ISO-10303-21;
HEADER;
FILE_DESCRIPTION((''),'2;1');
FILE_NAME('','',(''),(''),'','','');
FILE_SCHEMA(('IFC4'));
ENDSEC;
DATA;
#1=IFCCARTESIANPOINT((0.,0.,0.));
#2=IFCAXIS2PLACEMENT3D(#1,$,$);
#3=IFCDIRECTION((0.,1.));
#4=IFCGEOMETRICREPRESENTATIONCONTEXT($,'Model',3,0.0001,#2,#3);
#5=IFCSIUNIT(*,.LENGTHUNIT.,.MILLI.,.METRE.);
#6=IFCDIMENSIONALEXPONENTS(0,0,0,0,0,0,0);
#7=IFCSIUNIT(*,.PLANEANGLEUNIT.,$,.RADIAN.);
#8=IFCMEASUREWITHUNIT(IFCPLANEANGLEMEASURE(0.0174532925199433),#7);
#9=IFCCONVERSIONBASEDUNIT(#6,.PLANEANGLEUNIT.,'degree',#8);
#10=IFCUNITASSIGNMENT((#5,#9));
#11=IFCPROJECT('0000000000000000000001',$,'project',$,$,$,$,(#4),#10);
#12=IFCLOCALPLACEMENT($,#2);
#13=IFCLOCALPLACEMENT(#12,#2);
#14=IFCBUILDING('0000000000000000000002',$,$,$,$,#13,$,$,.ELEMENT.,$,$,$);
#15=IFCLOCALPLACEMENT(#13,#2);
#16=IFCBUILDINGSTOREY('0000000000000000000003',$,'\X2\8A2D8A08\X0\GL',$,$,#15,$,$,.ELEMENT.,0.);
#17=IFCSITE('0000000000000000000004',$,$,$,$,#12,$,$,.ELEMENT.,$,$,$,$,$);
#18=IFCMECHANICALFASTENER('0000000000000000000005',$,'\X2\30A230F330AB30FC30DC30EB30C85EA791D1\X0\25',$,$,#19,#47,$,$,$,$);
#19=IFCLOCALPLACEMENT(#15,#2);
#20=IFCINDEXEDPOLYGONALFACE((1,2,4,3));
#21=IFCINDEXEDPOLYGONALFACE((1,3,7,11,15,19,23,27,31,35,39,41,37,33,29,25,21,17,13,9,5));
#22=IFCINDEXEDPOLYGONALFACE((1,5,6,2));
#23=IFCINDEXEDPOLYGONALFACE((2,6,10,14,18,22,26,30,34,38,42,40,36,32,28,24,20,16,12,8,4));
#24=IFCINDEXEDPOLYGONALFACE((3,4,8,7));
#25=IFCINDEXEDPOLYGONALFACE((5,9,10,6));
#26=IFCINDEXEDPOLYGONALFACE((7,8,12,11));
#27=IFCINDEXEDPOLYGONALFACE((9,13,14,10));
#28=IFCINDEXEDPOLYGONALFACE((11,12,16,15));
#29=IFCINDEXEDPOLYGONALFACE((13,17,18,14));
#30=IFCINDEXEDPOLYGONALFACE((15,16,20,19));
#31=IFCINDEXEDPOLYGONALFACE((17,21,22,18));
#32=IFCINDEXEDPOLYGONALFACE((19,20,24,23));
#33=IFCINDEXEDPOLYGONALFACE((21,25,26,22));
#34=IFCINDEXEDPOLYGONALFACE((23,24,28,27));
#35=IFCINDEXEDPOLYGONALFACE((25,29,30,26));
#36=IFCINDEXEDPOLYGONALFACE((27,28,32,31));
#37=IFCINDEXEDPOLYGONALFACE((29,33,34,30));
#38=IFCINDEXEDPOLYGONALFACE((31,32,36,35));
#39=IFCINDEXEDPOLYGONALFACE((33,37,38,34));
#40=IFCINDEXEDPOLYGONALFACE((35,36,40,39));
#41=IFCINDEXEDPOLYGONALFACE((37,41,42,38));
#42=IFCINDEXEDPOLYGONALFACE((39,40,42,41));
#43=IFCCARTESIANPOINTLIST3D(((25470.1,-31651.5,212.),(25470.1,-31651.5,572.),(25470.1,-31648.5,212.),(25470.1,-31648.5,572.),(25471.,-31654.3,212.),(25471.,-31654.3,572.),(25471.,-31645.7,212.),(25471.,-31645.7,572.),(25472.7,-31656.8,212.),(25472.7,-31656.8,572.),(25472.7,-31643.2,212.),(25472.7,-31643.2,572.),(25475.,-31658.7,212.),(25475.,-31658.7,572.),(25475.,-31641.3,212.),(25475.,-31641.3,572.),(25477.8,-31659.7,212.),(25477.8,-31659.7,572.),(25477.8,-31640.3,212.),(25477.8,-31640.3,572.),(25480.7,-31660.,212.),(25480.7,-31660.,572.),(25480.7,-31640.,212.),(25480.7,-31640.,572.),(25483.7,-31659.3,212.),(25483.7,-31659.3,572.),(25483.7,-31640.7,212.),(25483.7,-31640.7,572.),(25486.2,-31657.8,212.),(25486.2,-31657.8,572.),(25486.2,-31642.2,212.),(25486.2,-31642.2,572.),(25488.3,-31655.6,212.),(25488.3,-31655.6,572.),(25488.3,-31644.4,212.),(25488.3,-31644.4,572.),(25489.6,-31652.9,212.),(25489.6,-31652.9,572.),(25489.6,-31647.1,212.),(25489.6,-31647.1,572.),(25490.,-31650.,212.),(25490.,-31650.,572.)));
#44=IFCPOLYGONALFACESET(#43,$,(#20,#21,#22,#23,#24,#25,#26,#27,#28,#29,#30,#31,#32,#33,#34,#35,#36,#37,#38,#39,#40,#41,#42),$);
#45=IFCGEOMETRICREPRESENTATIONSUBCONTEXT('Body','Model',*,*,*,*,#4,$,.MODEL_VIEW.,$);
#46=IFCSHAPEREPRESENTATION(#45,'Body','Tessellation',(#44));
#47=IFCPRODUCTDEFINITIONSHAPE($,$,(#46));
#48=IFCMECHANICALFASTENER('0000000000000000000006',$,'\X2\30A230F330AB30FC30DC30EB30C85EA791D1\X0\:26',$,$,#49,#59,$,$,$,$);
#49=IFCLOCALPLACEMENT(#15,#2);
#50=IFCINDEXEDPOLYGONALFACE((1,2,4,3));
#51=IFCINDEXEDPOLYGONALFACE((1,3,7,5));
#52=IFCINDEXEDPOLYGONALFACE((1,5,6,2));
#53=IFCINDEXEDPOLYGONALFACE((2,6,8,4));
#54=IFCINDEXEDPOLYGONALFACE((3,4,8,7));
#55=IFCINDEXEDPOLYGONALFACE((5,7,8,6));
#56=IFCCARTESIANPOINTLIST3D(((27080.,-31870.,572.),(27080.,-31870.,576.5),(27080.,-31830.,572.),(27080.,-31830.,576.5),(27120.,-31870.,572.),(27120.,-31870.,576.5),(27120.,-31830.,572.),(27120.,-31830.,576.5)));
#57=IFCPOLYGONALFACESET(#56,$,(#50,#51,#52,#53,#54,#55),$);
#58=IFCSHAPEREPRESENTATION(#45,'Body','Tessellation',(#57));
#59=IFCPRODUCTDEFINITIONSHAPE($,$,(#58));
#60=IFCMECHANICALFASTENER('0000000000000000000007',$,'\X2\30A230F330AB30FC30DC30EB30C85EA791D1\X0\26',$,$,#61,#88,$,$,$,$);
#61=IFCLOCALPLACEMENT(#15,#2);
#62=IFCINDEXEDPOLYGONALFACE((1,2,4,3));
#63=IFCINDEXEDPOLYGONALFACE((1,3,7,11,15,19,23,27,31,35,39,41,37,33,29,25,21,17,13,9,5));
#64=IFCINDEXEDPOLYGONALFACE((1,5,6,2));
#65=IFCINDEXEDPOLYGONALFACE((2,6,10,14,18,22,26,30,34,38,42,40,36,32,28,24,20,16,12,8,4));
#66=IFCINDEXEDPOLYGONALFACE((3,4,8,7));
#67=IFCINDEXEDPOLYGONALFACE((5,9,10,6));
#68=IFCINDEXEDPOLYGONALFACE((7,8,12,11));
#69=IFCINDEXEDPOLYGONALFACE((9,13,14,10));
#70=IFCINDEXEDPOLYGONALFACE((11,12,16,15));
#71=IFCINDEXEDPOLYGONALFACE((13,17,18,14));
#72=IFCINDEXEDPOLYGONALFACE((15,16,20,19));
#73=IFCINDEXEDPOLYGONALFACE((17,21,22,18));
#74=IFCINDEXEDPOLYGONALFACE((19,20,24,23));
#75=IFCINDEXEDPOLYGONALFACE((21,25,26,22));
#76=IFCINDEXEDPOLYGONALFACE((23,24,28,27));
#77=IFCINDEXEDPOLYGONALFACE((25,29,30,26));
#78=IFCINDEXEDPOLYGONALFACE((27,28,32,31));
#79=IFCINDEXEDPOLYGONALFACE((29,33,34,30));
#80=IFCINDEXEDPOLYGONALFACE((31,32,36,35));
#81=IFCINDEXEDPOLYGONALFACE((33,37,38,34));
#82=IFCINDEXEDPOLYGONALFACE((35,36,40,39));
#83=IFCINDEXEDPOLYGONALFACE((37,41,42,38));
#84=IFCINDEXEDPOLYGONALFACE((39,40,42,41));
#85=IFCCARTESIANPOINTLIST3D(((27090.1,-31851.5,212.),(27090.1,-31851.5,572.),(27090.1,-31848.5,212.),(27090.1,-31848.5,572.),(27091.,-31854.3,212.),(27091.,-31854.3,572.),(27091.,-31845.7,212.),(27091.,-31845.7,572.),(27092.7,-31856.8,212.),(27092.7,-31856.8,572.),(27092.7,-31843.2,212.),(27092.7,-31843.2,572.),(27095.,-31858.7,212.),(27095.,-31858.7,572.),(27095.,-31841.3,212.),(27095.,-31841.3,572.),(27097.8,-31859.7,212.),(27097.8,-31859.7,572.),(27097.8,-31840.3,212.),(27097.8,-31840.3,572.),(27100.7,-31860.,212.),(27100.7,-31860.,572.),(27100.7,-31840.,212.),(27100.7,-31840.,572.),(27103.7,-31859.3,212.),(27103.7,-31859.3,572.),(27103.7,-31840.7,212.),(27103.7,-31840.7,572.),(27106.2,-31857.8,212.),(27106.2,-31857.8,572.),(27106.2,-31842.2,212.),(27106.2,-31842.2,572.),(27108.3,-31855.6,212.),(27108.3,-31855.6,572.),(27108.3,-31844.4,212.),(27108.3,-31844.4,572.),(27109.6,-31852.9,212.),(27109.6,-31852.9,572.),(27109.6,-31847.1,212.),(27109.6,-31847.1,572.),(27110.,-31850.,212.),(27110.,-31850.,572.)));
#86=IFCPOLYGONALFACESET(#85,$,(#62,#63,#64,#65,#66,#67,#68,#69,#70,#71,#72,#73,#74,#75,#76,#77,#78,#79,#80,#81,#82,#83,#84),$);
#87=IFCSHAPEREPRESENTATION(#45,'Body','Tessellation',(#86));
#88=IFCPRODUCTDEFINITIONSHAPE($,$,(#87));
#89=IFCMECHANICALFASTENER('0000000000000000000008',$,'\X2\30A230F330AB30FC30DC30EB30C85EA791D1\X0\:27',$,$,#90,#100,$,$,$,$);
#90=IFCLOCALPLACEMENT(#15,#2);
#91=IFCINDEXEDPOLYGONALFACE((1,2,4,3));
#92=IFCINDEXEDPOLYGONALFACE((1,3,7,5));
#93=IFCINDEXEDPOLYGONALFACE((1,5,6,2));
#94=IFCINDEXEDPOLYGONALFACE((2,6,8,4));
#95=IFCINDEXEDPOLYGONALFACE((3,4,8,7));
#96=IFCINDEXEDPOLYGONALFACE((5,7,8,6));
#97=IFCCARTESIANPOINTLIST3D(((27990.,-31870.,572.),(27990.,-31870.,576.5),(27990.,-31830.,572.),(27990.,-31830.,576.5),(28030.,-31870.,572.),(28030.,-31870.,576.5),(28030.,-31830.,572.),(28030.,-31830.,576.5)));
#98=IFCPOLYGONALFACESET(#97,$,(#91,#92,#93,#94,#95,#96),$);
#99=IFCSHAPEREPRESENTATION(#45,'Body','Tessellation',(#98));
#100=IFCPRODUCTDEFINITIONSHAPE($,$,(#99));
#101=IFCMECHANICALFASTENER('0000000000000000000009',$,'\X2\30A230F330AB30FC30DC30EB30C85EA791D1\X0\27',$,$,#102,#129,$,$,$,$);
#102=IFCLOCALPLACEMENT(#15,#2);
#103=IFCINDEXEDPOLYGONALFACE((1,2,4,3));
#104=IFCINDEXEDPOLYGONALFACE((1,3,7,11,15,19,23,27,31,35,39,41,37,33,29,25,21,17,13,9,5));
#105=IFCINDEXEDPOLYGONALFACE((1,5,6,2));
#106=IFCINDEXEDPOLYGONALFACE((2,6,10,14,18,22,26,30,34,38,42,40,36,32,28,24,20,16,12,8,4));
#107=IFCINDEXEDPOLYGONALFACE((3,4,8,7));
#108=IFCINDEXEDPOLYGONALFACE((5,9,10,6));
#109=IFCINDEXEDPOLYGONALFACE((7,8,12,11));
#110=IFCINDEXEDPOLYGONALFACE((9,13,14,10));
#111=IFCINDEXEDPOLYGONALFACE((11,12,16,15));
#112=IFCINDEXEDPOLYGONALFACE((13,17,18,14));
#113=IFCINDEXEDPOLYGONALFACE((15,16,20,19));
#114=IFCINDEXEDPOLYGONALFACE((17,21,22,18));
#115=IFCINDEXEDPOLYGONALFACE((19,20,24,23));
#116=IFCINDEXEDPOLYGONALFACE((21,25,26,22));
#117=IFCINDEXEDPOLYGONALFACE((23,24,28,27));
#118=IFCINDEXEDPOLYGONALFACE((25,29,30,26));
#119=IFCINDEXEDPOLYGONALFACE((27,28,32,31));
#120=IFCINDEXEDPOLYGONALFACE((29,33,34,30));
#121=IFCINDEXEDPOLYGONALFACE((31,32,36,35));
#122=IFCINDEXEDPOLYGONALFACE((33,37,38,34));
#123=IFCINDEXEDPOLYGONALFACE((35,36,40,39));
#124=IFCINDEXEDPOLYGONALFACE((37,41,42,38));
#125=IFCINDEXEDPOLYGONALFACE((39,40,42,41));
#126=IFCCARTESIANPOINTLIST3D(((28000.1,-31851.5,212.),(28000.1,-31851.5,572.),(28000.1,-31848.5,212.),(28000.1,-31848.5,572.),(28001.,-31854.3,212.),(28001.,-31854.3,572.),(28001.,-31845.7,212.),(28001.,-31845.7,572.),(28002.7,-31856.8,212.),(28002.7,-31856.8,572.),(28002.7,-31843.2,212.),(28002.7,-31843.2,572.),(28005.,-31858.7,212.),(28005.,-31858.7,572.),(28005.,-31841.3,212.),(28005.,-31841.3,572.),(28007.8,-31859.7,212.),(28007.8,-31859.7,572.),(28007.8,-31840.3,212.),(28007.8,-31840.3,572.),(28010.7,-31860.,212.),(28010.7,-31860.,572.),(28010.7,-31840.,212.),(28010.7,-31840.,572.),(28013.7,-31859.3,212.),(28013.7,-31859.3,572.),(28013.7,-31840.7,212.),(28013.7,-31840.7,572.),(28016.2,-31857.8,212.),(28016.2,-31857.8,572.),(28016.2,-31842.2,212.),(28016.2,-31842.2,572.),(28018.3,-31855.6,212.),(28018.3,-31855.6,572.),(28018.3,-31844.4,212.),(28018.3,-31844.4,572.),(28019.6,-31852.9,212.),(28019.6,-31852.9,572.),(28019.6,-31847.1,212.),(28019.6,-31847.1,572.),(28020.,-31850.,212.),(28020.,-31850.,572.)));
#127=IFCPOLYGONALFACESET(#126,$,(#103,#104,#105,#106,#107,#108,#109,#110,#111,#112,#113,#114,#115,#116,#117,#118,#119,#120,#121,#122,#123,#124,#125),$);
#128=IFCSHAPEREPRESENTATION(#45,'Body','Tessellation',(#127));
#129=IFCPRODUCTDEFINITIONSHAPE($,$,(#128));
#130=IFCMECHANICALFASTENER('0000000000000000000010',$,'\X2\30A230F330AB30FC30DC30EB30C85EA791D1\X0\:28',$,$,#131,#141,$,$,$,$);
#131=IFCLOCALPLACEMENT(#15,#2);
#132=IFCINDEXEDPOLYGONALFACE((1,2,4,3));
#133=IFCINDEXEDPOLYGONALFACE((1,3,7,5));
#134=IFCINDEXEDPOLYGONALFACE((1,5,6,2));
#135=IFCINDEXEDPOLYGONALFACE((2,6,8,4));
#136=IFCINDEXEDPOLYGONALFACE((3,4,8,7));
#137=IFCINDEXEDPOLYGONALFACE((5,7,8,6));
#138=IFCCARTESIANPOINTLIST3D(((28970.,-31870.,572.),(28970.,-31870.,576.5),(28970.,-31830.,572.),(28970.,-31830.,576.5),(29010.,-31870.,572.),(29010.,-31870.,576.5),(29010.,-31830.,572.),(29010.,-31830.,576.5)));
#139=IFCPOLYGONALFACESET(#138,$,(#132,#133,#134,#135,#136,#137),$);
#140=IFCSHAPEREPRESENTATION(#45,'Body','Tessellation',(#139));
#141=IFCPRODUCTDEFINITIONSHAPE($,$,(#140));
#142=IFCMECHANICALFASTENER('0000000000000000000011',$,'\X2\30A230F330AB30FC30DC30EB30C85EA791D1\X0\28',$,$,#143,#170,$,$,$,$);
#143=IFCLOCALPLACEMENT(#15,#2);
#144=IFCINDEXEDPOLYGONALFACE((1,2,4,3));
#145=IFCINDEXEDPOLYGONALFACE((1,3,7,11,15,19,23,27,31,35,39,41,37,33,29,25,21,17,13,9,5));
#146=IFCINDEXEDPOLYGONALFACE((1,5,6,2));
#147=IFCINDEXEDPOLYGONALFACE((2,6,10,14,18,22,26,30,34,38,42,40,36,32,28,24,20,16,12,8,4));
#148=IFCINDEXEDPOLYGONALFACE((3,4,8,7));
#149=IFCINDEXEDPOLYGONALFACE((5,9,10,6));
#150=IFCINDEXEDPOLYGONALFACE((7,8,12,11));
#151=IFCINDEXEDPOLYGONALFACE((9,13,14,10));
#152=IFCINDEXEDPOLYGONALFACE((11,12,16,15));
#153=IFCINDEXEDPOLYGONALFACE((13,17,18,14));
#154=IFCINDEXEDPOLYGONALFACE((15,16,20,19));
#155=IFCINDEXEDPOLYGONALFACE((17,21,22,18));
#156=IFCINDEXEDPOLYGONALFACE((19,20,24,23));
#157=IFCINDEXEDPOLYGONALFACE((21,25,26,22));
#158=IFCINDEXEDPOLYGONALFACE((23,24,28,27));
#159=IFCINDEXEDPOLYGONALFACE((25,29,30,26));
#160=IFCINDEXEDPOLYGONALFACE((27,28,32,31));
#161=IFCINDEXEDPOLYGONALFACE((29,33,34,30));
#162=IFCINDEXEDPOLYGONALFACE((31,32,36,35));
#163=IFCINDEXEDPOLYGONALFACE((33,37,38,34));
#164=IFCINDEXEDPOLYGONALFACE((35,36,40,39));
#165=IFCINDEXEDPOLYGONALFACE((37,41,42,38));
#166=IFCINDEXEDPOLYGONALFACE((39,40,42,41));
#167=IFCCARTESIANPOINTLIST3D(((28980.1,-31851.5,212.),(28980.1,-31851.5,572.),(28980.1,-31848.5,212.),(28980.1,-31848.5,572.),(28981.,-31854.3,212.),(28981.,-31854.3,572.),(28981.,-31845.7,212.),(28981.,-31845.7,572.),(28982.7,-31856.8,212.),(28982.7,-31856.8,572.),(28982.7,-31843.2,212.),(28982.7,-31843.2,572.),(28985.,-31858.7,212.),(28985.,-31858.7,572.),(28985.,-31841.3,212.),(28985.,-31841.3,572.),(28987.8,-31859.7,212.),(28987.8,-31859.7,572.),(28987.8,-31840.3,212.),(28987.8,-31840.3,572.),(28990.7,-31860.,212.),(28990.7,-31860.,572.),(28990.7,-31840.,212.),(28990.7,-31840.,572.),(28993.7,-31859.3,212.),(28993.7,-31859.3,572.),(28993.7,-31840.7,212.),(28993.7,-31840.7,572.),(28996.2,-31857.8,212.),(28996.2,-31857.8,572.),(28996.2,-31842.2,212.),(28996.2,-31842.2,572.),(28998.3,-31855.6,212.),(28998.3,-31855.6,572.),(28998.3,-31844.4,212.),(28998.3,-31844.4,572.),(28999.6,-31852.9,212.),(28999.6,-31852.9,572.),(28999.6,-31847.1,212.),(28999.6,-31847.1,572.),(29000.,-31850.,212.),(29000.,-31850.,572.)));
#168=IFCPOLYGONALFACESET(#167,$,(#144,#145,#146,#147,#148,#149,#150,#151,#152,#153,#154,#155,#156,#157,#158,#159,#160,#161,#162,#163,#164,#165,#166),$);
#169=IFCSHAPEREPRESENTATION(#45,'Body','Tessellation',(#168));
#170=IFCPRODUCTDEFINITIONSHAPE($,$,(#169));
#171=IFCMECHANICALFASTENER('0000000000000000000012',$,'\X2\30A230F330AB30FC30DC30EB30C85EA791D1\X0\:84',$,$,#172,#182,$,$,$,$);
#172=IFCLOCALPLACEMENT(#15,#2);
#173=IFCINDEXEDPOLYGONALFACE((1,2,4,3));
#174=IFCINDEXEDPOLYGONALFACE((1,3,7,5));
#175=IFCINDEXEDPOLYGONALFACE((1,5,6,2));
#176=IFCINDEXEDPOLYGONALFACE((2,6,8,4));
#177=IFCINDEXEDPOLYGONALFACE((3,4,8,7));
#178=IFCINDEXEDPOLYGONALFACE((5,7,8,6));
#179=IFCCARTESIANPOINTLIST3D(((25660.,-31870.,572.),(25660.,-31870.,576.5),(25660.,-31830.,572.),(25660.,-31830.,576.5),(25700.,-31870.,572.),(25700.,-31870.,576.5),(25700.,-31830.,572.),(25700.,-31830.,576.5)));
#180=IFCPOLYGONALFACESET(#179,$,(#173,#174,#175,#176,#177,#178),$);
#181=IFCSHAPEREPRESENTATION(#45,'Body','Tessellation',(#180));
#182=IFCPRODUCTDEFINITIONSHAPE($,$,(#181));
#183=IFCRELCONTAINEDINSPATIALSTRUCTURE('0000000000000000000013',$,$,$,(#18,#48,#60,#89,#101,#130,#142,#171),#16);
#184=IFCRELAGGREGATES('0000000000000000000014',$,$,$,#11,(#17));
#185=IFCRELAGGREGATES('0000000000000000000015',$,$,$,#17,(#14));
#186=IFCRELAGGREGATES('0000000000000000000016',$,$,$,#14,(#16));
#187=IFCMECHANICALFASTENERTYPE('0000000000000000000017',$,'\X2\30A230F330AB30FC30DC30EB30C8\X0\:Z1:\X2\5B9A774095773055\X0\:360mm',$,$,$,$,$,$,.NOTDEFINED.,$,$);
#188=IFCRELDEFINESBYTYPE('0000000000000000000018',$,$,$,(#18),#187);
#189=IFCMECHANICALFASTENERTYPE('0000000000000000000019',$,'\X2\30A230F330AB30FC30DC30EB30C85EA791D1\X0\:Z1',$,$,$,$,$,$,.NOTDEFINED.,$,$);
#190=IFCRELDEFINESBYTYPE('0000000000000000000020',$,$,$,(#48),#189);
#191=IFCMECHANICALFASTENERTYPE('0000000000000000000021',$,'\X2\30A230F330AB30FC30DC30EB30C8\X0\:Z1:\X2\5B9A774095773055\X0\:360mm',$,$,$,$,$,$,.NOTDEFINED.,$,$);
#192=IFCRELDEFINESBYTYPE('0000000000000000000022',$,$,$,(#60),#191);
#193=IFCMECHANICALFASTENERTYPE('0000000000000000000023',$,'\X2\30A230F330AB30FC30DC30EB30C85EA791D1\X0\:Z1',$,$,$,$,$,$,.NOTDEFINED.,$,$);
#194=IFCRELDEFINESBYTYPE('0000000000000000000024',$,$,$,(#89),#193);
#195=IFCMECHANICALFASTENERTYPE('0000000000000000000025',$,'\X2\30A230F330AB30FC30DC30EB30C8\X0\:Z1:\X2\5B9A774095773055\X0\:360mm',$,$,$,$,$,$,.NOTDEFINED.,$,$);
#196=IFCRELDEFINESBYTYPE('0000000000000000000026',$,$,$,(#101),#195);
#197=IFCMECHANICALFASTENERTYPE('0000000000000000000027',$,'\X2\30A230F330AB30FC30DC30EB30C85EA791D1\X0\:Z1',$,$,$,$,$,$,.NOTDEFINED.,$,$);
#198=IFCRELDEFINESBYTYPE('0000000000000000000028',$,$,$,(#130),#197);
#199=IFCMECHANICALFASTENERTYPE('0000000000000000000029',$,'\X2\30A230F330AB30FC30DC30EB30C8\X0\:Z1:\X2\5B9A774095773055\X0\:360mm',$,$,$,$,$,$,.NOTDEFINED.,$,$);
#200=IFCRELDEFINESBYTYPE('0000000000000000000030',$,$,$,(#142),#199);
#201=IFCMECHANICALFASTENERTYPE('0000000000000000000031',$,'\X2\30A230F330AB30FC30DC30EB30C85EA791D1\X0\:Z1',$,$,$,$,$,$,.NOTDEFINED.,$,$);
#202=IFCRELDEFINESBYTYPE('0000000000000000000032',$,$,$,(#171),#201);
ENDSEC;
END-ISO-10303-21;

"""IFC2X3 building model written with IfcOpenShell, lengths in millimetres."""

from ifc_helpers import new_model, entity, si_unit, converted_unit, direction, frame, origin, origin_with_axes, origin_2d, place, context, subcontext, project, spatial, rectangle, circle, extrude, type_object, element, save


model = new_model("IFC2X3")

# Units and contexts
model_context = context("Model", 3, precision=0.0001, world=origin(), true_north=direction((0.0, 1.0)))
body_context = subcontext(model_context, "Body", "Model", "MODEL_VIEW")
ifc_project = project(units=[si_unit("LENGTHUNIT", "METRE", prefix="MILLI"), converted_unit("PLANEANGLEUNIT", "degree", entity("IfcPlaneAngleMeasure", 0.0174532925199433), si_unit("PLANEANGLEUNIT", "RADIAN"), dimensions=[0, 0, 0, 0, 0, 0, 0])], contexts=[model_context])

# Site, building, storey
site_placement = place(None, origin())
site = spatial("IfcSite", under=ifc_project, at=site_placement, CompositionType="ELEMENT")
building_placement = place(site_placement, origin())
building = spatial("IfcBuilding", under=site, at=building_placement, CompositionType="ELEMENT")
storey_placement = place(building_placement, origin())
storey = spatial("IfcBuildingStorey", under=building, at=storey_placement, Name="設計GL", CompositionType="ELEMENT", Elevation=0.0)

# Mechanical fasteners
mechanical_fastener_type_1 = type_object("IfcMechanicalFastenerType", Name="アンカーボルト:Z1:定着長さ:360mm")
mechanical_fastener_1_placement = place(storey_placement, frame((25480.0, -31650.0, 212.0)))
element("IfcMechanicalFastener", 1, at=mechanical_fastener_1_placement, inside=storey, type_object=mechanical_fastener_type_1, Name="アンカーボルト座金25", context=body_context, shape_type="SweptSolid", body=[
    extrude(circle(Radius=10.0, at=origin_2d()), origin_with_axes(), (0.0, 0.0, 1.0), 360.0),
])
mechanical_fastener_type_2 = type_object("IfcMechanicalFastenerType", Name="アンカーボルト座金:Z1")
mechanical_fastener_2_placement = place(storey_placement, frame((27100.0, -31850.0, 572.0)))
element("IfcMechanicalFastener", 2, at=mechanical_fastener_2_placement, inside=storey, type_object=mechanical_fastener_type_2, Name="アンカーボルト座金:26", context=body_context, shape_type="SweptSolid", body=[
    extrude(rectangle(XDim=40.0, YDim=40.0, at=origin_2d()), origin_with_axes(), (0.0, 0.0, 1.0), 4.5),
])
mechanical_fastener_type_3 = type_object("IfcMechanicalFastenerType", Name="アンカーボルト:Z1:定着長さ:360mm")
mechanical_fastener_3_placement = place(storey_placement, frame((27100.0, -31850.0, 212.0)))
element("IfcMechanicalFastener", 3, at=mechanical_fastener_3_placement, inside=storey, type_object=mechanical_fastener_type_3, Name="アンカーボルト座金26", context=body_context, shape_type="SweptSolid", body=[
    extrude(circle(Radius=10.0, at=origin_2d()), origin_with_axes(), (0.0, 0.0, 1.0), 360.0),
])
mechanical_fastener_type_4 = type_object("IfcMechanicalFastenerType", Name="アンカーボルト座金:Z1")
mechanical_fastener_4_placement = place(storey_placement, frame((28010.0, -31850.0, 572.0)))
element("IfcMechanicalFastener", 4, at=mechanical_fastener_4_placement, inside=storey, type_object=mechanical_fastener_type_4, Name="アンカーボルト座金:27", context=body_context, shape_type="SweptSolid", body=[
    extrude(rectangle(XDim=40.0, YDim=40.0, at=origin_2d()), origin_with_axes(), (0.0, 0.0, 1.0), 4.5),
])
mechanical_fastener_type_5 = type_object("IfcMechanicalFastenerType", Name="アンカーボルト:Z1:定着長さ:360mm")
mechanical_fastener_5_placement = place(storey_placement, frame((28010.0, -31850.0, 212.0)))
element("IfcMechanicalFastener", 5, at=mechanical_fastener_5_placement, inside=storey, type_object=mechanical_fastener_type_5, Name="アンカーボルト座金27", context=body_context, shape_type="SweptSolid", body=[
    extrude(circle(Radius=10.0, at=origin_2d()), origin_with_axes(), (0.0, 0.0, 1.0), 360.0),
])
mechanical_fastener_type_6 = type_object("IfcMechanicalFastenerType", Name="アンカーボルト座金:Z1")
mechanical_fastener_6_placement = place(storey_placement, frame((28990.0, -31850.0, 572.0)))
element("IfcMechanicalFastener", 6, at=mechanical_fastener_6_placement, inside=storey, type_object=mechanical_fastener_type_6, Name="アンカーボルト座金:28", context=body_context, shape_type="SweptSolid", body=[
    extrude(rectangle(XDim=40.0, YDim=40.0, at=origin_2d()), origin_with_axes(), (0.0, 0.0, 1.0), 4.5),
])
mechanical_fastener_type_7 = type_object("IfcMechanicalFastenerType", Name="アンカーボルト:Z1:定着長さ:360mm")
mechanical_fastener_7_placement = place(storey_placement, frame((28990.0, -31850.0, 212.0)))
element("IfcMechanicalFastener", 7, at=mechanical_fastener_7_placement, inside=storey, type_object=mechanical_fastener_type_7, Name="アンカーボルト座金28", context=body_context, shape_type="SweptSolid", body=[
    extrude(circle(Radius=10.0, at=origin_2d()), origin_with_axes(), (0.0, 0.0, 1.0), 360.0),
])
mechanical_fastener_type_8 = type_object("IfcMechanicalFastenerType", Name="アンカーボルト座金:Z1")
mechanical_fastener_8_placement = place(storey_placement, frame((25680.0, -31850.0, 572.0)))
element("IfcMechanicalFastener", 8, at=mechanical_fastener_8_placement, inside=storey, type_object=mechanical_fastener_type_8, Name="アンカーボルト座金:84", context=body_context, shape_type="SweptSolid", body=[
    extrude(rectangle(XDim=40.0, YDim=40.0, at=origin_2d()), origin_with_axes(), (0.0, 0.0, 1.0), 4.5),
])

save(model, "model.ifc")
